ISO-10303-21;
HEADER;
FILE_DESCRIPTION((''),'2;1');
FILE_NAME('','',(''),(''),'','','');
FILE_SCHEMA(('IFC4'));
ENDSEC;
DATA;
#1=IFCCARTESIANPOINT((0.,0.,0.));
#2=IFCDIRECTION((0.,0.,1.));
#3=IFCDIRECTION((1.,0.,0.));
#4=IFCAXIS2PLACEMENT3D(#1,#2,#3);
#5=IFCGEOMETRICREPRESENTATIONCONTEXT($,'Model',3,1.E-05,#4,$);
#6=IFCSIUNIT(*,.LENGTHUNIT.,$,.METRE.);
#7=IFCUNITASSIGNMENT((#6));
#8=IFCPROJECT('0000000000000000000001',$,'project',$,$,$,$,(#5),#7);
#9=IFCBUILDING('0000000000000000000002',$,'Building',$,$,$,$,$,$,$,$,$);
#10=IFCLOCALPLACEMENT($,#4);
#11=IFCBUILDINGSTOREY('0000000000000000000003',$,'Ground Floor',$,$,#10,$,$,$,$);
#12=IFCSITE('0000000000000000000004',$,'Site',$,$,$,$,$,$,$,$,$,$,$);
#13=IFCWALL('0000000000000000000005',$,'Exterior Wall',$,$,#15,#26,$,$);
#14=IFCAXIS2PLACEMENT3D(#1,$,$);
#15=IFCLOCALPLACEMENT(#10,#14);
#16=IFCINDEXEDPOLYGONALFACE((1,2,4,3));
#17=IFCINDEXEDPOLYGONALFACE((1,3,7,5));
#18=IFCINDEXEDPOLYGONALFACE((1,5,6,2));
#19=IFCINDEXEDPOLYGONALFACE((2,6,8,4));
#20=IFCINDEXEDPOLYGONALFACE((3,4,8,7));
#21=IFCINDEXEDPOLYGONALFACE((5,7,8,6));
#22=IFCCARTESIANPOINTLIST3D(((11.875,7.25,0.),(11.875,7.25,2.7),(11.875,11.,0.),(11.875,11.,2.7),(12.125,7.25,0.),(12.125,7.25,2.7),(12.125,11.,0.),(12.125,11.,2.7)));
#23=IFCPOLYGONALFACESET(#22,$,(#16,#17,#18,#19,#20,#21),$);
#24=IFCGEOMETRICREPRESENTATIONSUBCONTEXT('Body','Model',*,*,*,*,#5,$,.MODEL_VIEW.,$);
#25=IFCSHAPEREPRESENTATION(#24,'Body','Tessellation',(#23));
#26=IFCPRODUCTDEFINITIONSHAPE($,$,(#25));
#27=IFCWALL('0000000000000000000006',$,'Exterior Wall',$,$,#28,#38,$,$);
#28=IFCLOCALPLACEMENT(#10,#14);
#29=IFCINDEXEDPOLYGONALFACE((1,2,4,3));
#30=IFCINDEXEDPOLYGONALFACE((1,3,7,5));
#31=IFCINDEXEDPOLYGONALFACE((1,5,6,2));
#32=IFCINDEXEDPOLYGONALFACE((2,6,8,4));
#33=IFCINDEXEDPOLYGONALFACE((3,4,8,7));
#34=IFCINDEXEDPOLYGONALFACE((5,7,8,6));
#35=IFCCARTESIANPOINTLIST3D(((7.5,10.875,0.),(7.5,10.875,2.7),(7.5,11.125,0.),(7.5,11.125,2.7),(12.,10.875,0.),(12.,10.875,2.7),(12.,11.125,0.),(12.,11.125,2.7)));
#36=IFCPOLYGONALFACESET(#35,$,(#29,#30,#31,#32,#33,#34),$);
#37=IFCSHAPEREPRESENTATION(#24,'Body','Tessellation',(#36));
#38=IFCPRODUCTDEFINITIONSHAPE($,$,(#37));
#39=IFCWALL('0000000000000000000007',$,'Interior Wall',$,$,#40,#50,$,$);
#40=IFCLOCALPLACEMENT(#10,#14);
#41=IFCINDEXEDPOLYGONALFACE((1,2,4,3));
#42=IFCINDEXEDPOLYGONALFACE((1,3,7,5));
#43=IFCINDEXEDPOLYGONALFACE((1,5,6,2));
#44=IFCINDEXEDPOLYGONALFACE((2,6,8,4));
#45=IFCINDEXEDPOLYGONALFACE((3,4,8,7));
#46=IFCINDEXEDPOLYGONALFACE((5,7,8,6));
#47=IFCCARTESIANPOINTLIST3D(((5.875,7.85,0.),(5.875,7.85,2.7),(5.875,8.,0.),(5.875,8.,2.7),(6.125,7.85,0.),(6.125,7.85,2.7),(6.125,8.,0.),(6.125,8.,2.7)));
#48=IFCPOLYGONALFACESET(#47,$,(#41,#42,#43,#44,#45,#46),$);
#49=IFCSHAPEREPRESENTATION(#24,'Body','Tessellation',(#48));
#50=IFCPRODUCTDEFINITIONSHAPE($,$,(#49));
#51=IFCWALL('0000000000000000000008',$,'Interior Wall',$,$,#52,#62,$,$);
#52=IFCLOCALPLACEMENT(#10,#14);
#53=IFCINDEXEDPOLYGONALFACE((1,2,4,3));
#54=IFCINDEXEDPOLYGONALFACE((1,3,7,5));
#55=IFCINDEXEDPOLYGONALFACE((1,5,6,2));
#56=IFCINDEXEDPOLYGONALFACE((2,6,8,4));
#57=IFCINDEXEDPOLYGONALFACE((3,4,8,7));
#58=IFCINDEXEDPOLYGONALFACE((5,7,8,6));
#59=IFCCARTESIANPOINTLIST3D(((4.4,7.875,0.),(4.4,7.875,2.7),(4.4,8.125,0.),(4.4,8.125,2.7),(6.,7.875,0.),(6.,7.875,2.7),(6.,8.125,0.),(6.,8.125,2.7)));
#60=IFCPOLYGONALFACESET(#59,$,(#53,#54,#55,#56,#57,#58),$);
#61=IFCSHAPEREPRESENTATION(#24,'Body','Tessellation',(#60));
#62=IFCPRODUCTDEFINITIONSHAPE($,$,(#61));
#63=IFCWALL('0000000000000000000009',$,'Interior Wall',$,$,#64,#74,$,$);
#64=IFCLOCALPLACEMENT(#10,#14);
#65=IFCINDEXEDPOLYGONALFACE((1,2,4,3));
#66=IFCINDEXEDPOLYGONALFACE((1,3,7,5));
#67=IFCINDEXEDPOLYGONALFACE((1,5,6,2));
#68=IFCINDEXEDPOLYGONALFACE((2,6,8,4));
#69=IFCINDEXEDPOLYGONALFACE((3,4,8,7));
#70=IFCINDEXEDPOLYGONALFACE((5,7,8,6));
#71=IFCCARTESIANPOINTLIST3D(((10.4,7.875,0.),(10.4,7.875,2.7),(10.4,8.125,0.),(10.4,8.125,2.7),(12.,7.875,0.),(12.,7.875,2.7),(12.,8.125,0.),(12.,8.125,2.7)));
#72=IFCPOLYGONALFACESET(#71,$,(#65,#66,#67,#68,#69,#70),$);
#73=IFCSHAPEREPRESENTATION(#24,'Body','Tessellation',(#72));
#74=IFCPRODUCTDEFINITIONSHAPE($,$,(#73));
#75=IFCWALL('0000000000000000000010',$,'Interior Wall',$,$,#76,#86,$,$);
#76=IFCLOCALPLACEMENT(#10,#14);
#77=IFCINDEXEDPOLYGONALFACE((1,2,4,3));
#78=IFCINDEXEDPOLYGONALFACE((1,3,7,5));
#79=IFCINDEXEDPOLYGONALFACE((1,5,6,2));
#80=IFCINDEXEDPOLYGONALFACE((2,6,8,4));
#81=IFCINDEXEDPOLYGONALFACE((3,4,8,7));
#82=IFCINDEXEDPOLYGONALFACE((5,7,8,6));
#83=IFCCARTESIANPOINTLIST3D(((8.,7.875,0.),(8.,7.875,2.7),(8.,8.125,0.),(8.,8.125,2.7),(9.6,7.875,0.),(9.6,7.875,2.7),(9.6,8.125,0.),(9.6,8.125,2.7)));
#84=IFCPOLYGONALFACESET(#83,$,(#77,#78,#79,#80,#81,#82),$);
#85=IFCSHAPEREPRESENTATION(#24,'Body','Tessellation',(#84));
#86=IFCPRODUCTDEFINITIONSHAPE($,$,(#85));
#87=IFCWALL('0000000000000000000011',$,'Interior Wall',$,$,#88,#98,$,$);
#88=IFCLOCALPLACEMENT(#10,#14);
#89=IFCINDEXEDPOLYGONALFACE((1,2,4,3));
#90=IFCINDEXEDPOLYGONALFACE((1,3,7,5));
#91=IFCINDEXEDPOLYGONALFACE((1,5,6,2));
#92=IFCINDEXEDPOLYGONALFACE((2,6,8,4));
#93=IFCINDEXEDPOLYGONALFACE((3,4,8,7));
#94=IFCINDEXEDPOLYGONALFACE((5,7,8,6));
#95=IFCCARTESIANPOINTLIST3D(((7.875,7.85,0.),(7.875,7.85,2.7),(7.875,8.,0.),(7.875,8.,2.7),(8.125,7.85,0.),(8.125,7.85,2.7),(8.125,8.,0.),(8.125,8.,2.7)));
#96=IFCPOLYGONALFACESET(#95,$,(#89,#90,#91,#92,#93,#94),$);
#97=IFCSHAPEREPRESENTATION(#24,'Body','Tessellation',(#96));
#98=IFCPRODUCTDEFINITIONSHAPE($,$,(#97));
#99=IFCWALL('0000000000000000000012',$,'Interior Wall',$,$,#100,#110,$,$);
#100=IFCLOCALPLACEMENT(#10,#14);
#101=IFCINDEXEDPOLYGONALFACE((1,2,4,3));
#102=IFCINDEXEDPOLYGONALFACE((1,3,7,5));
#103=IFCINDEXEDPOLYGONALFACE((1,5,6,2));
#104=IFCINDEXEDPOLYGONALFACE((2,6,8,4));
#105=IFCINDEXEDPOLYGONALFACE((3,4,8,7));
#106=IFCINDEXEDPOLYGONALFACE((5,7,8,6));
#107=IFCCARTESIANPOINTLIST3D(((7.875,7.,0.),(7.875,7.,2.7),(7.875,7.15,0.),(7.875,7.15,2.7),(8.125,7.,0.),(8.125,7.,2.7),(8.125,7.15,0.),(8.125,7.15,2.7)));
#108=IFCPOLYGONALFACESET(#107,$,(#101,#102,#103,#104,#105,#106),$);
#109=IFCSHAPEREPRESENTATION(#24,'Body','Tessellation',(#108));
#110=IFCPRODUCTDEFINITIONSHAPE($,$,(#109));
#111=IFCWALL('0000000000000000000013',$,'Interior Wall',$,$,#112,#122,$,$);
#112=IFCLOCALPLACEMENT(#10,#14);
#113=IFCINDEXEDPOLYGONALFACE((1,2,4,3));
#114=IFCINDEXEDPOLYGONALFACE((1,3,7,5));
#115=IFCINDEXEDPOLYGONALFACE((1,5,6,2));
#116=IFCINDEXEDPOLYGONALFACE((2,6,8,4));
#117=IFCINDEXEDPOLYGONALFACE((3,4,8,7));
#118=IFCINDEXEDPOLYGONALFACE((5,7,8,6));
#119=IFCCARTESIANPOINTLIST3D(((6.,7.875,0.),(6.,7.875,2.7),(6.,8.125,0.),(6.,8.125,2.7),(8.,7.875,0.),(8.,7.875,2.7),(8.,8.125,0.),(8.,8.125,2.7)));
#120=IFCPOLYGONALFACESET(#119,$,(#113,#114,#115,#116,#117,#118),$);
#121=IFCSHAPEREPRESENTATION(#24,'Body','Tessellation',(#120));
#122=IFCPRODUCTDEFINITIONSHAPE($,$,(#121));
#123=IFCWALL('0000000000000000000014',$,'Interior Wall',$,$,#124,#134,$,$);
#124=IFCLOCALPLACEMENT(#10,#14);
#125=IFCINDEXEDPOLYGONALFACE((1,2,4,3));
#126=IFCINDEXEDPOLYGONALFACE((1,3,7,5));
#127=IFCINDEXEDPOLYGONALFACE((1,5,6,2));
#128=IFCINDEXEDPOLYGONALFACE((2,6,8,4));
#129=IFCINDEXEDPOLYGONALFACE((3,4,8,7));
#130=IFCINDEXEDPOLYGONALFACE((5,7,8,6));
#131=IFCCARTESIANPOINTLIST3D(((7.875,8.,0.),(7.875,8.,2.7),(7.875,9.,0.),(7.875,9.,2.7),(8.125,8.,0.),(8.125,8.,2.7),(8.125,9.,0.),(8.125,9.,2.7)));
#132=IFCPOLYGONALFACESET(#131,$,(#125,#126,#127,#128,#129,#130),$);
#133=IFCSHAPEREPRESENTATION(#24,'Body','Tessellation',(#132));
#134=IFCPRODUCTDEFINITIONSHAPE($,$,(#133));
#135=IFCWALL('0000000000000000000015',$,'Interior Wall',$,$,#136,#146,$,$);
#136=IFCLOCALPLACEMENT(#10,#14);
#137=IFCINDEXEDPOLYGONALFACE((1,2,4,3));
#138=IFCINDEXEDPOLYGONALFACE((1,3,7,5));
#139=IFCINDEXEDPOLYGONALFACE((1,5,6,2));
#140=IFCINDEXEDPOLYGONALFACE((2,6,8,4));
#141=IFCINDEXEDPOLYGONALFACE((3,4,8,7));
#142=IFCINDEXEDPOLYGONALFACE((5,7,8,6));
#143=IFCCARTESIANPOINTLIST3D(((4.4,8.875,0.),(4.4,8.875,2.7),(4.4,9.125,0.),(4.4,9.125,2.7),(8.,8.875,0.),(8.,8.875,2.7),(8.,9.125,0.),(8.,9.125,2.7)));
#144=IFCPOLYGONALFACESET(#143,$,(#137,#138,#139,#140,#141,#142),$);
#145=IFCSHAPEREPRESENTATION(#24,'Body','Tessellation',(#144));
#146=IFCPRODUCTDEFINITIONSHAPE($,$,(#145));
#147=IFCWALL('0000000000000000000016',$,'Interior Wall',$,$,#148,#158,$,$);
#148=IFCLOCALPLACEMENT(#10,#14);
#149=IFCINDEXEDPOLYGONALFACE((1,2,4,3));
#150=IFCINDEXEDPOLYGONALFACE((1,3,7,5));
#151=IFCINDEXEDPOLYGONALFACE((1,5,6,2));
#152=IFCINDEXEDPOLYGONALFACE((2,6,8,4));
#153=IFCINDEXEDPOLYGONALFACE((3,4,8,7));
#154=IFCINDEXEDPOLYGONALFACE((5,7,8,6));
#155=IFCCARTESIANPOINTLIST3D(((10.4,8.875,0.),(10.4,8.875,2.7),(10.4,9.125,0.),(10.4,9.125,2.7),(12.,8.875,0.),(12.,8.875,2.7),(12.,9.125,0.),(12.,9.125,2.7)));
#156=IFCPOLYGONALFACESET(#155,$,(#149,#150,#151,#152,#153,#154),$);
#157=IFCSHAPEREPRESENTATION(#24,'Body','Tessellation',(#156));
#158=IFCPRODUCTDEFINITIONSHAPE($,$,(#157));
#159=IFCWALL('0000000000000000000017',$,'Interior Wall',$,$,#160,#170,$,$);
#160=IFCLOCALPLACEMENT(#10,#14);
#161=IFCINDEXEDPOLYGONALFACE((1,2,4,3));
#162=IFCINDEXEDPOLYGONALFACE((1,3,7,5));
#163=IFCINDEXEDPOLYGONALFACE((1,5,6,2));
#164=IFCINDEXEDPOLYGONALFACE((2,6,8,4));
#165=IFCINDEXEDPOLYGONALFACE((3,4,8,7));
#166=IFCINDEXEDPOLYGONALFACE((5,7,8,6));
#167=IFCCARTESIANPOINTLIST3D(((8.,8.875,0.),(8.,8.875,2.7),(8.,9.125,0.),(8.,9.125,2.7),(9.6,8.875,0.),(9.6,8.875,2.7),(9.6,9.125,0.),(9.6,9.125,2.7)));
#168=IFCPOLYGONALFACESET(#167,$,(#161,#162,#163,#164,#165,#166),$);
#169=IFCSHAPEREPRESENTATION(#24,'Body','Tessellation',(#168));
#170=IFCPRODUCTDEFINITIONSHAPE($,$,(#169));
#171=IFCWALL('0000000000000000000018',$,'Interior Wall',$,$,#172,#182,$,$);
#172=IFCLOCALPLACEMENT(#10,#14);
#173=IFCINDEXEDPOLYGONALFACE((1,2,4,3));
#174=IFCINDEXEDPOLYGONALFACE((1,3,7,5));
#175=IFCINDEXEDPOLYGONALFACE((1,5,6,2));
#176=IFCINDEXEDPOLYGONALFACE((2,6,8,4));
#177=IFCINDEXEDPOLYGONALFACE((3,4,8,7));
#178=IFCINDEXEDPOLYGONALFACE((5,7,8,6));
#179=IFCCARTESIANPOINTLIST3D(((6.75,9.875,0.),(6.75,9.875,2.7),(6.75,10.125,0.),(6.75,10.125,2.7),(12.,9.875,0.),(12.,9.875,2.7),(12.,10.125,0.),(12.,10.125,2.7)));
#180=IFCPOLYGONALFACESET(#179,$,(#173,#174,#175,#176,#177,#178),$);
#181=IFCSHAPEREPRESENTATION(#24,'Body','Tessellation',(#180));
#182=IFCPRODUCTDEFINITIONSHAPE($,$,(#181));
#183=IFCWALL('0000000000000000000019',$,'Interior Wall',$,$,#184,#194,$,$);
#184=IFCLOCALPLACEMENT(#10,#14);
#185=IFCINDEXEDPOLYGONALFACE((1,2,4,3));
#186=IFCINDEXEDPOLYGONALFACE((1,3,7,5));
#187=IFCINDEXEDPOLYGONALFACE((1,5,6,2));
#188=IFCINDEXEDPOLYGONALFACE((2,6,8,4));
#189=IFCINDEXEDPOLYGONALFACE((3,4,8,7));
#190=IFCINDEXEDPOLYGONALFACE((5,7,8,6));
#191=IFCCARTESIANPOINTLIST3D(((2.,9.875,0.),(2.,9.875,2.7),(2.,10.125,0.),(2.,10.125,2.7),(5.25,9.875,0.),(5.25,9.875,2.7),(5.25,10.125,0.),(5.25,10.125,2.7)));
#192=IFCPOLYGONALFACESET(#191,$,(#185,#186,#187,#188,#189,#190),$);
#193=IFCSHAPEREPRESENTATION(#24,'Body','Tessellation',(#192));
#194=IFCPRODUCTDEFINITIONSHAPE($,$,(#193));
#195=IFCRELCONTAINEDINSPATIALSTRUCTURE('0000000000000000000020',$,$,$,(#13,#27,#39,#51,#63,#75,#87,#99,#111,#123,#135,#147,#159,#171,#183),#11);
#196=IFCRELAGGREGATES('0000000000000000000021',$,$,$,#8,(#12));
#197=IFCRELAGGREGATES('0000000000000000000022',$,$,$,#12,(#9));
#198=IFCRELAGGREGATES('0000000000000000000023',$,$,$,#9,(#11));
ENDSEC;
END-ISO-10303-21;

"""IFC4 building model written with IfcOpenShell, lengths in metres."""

from ifc_helpers import new_model, si_unit, frame, origin_with_axes, place, context, subcontext, project, spatial, indexed_curve, outline, extrude, element, save


model = new_model("IFC4")

# Units and contexts
model_context = context("Model", 3, precision=1e-05, world=origin_with_axes())
body_context = subcontext(model_context, "Body", "Model", "MODEL_VIEW")
ifc_project = project(units=[si_unit("LENGTHUNIT", "METRE")], contexts=[model_context])

# Site, building, storey
site = spatial("IfcSite", under=ifc_project, Name="Site")
building = spatial("IfcBuilding", under=site, Name="Building")
storey_placement = place(None, origin_with_axes())
storey = spatial("IfcBuildingStorey", under=building, at=storey_placement, Name="Ground Floor")

# Walls
wall_1_placement = place(storey_placement, frame((12.0, 7.25, 0.0), z_axis=(0.0, 0.0, 1.0), x_axis=(0.0, 1.0, 0.0)))
element("IfcWall", 1, at=wall_1_placement, inside=storey, Name="Exterior Wall", context=body_context, shape_type="SweptSolid", body=[
    extrude(outline(indexed_curve([(0.0, 0.0), (0.0, 0.25), (3.75, 0.25), (3.75, 0.0), (0.0, 0.0)], self_intersect=False)), frame((0.0, -0.125, 0.0), z_axis=(0.0, 0.0, 1.0), x_axis=(1.0, 0.0, 0.0)), (0.0, 0.0, 1.0), 2.7),
])
wall_2_placement = place(storey_placement, frame((12.0, 11.0, 0.0), z_axis=(0.0, 0.0, 1.0), x_axis=(-1.0, 0.0, 0.0)))
element("IfcWall", 2, at=wall_2_placement, inside=storey, Name="Exterior Wall", context=body_context, shape_type="SweptSolid", body=[
    extrude(outline(indexed_curve([(0.0, 0.0), (0.0, 0.25), (4.5, 0.25), (4.5, 0.0), (0.0, 0.0)], self_intersect=False)), frame((0.0, -0.125, 0.0), z_axis=(0.0, 0.0, 1.0), x_axis=(1.0, 0.0, 0.0)), (0.0, 0.0, 1.0), 2.7),
])
wall_3_placement = place(storey_placement, frame((6.0, 7.85, 0.0), z_axis=(0.0, 0.0, 1.0), x_axis=(0.0, 1.0, 0.0)))
element("IfcWall", 3, at=wall_3_placement, inside=storey, Name="Interior Wall", context=body_context, shape_type="SweptSolid", body=[
    extrude(outline(indexed_curve([(0.0, 0.0), (0.0, 0.25), (0.15, 0.25), (0.15, 0.0), (0.0, 0.0)], self_intersect=False)), frame((0.0, -0.125, 0.0), z_axis=(0.0, 0.0, 1.0), x_axis=(1.0, 0.0, 0.0)), (0.0, 0.0, 1.0), 2.7),
])
for number, where, z_axis, x_axis, name in (
    (4, (6.0, 8.0, 0.0), (0.0, 0.0, 1.0), (-1.0, 0.0, 0.0), "Interior Wall"),
    (5, (12.0, 8.0, 0.0), (0.0, 0.0, 1.0), (-1.0, 0.0, 0.0), "Interior Wall"),
    (6, (9.6, 8.0, 0.0), (0.0, 0.0, 1.0), (-1.0, 0.0, 0.0), "Interior Wall"),
):
    element("IfcWall", number, at=place(storey_placement, frame(where, z_axis=z_axis, x_axis=x_axis)), inside=storey, Name=name, context=body_context, shape_type="SweptSolid", body=[
        extrude(outline(indexed_curve([(0.0, 0.0), (0.0, 0.25), (1.6, 0.25), (1.6, 0.0), (0.0, 0.0)], self_intersect=False)), frame((0.0, -0.125, 0.0), z_axis=(0.0, 0.0, 1.0), x_axis=(1.0, 0.0, 0.0)), (0.0, 0.0, 1.0), 2.7),
    ])
for number, where, z_axis, x_axis, name in (
    (7, (8.0, 8.0, 0.0), (0.0, 0.0, 1.0), (0.0, -1.0, 0.0), "Interior Wall"),
    (8, (8.0, 7.15, 0.0), (0.0, 0.0, 1.0), (0.0, -1.0, 0.0), "Interior Wall"),
):
    element("IfcWall", number, at=place(storey_placement, frame(where, z_axis=z_axis, x_axis=x_axis)), inside=storey, Name=name, context=body_context, shape_type="SweptSolid", body=[
        extrude(outline(indexed_curve([(0.0, 0.0), (0.0, 0.25), (0.15, 0.25), (0.15, 0.0), (0.0, 0.0)], self_intersect=False)), frame((0.0, -0.125, 0.0), z_axis=(0.0, 0.0, 1.0), x_axis=(1.0, 0.0, 0.0)), (0.0, 0.0, 1.0), 2.7),
    ])
wall_4_placement = place(storey_placement, frame((8.0, 8.0, 0.0), z_axis=(0.0, 0.0, 1.0), x_axis=(-1.0, 0.0, 0.0)))
element("IfcWall", 9, at=wall_4_placement, inside=storey, Name="Interior Wall", context=body_context, shape_type="SweptSolid", body=[
    extrude(outline(indexed_curve([(0.0, 0.0), (0.0, 0.25), (2.0, 0.25), (2.0, 0.0), (0.0, 0.0)], self_intersect=False)), frame((0.0, -0.125, 0.0), z_axis=(0.0, 0.0, 1.0), x_axis=(1.0, 0.0, 0.0)), (0.0, 0.0, 1.0), 2.7),
])
wall_5_placement = place(storey_placement, frame((8.0, 8.0, 0.0), z_axis=(0.0, 0.0, 1.0), x_axis=(0.0, 1.0, 0.0)))
element("IfcWall", 10, at=wall_5_placement, inside=storey, Name="Interior Wall", context=body_context, shape_type="SweptSolid", body=[
    extrude(outline(indexed_curve([(0.0, 0.0), (0.0, 0.25), (1.0, 0.25), (1.0, 0.0), (0.0, 0.0)], self_intersect=False)), frame((0.0, -0.125, 0.0), z_axis=(0.0, 0.0, 1.0), x_axis=(1.0, 0.0, 0.0)), (0.0, 0.0, 1.0), 2.7),
])
wall_6_placement = place(storey_placement, frame((8.0, 9.0, 0.0), z_axis=(0.0, 0.0, 1.0), x_axis=(-1.0, 0.0, 0.0)))
element("IfcWall", 11, at=wall_6_placement, inside=storey, Name="Interior Wall", context=body_context, shape_type="SweptSolid", body=[
    extrude(outline(indexed_curve([(0.0, 0.0), (0.0, 0.25), (3.6, 0.25), (3.6, 0.0), (0.0, 0.0)], self_intersect=False)), frame((0.0, -0.125, 0.0), z_axis=(0.0, 0.0, 1.0), x_axis=(1.0, 0.0, 0.0)), (0.0, 0.0, 1.0), 2.7),
])
for number, where, z_axis, x_axis, name in (
    (12, (12.0, 9.0, 0.0), (0.0, 0.0, 1.0), (-1.0, 0.0, 0.0), "Interior Wall"),
    (13, (9.6, 9.0, 0.0), (0.0, 0.0, 1.0), (-1.0, 0.0, 0.0), "Interior Wall"),
):
    element("IfcWall", number, at=place(storey_placement, frame(where, z_axis=z_axis, x_axis=x_axis)), inside=storey, Name=name, context=body_context, shape_type="SweptSolid", body=[
        extrude(outline(indexed_curve([(0.0, 0.0), (0.0, 0.25), (1.6, 0.25), (1.6, 0.0), (0.0, 0.0)], self_intersect=False)), frame((0.0, -0.125, 0.0), z_axis=(0.0, 0.0, 1.0), x_axis=(1.0, 0.0, 0.0)), (0.0, 0.0, 1.0), 2.7),
    ])
wall_7_placement = place(storey_placement, frame((12.0, 10.0, 0.0), z_axis=(0.0, 0.0, 1.0), x_axis=(-1.0, 0.0, 0.0)))
element("IfcWall", 14, at=wall_7_placement, inside=storey, Name="Interior Wall", context=body_context, shape_type="SweptSolid", body=[
    extrude(outline(indexed_curve([(0.0, 0.0), (0.0, 0.25), (5.25, 0.25), (5.25, 0.0), (0.0, 0.0)], self_intersect=False)), frame((0.0, -0.125, 0.0), z_axis=(0.0, 0.0, 1.0), x_axis=(1.0, 0.0, 0.0)), (0.0, 0.0, 1.0), 2.7),
])
wall_8_placement = place(storey_placement, frame((5.25, 10.0, 0.0), z_axis=(0.0, 0.0, 1.0), x_axis=(-1.0, 0.0, 0.0)))
element("IfcWall", 15, at=wall_8_placement, inside=storey, Name="Interior Wall", context=body_context, shape_type="SweptSolid", body=[
    extrude(outline(indexed_curve([(0.0, 0.0), (0.0, 0.25), (3.25, 0.25), (3.25, 0.0), (0.0, 0.0)], self_intersect=False)), frame((0.0, -0.125, 0.0), z_axis=(0.0, 0.0, 1.0), x_axis=(1.0, 0.0, 0.0)), (0.0, 0.0, 1.0), 2.7),
])

save(model, "model.ifc")
